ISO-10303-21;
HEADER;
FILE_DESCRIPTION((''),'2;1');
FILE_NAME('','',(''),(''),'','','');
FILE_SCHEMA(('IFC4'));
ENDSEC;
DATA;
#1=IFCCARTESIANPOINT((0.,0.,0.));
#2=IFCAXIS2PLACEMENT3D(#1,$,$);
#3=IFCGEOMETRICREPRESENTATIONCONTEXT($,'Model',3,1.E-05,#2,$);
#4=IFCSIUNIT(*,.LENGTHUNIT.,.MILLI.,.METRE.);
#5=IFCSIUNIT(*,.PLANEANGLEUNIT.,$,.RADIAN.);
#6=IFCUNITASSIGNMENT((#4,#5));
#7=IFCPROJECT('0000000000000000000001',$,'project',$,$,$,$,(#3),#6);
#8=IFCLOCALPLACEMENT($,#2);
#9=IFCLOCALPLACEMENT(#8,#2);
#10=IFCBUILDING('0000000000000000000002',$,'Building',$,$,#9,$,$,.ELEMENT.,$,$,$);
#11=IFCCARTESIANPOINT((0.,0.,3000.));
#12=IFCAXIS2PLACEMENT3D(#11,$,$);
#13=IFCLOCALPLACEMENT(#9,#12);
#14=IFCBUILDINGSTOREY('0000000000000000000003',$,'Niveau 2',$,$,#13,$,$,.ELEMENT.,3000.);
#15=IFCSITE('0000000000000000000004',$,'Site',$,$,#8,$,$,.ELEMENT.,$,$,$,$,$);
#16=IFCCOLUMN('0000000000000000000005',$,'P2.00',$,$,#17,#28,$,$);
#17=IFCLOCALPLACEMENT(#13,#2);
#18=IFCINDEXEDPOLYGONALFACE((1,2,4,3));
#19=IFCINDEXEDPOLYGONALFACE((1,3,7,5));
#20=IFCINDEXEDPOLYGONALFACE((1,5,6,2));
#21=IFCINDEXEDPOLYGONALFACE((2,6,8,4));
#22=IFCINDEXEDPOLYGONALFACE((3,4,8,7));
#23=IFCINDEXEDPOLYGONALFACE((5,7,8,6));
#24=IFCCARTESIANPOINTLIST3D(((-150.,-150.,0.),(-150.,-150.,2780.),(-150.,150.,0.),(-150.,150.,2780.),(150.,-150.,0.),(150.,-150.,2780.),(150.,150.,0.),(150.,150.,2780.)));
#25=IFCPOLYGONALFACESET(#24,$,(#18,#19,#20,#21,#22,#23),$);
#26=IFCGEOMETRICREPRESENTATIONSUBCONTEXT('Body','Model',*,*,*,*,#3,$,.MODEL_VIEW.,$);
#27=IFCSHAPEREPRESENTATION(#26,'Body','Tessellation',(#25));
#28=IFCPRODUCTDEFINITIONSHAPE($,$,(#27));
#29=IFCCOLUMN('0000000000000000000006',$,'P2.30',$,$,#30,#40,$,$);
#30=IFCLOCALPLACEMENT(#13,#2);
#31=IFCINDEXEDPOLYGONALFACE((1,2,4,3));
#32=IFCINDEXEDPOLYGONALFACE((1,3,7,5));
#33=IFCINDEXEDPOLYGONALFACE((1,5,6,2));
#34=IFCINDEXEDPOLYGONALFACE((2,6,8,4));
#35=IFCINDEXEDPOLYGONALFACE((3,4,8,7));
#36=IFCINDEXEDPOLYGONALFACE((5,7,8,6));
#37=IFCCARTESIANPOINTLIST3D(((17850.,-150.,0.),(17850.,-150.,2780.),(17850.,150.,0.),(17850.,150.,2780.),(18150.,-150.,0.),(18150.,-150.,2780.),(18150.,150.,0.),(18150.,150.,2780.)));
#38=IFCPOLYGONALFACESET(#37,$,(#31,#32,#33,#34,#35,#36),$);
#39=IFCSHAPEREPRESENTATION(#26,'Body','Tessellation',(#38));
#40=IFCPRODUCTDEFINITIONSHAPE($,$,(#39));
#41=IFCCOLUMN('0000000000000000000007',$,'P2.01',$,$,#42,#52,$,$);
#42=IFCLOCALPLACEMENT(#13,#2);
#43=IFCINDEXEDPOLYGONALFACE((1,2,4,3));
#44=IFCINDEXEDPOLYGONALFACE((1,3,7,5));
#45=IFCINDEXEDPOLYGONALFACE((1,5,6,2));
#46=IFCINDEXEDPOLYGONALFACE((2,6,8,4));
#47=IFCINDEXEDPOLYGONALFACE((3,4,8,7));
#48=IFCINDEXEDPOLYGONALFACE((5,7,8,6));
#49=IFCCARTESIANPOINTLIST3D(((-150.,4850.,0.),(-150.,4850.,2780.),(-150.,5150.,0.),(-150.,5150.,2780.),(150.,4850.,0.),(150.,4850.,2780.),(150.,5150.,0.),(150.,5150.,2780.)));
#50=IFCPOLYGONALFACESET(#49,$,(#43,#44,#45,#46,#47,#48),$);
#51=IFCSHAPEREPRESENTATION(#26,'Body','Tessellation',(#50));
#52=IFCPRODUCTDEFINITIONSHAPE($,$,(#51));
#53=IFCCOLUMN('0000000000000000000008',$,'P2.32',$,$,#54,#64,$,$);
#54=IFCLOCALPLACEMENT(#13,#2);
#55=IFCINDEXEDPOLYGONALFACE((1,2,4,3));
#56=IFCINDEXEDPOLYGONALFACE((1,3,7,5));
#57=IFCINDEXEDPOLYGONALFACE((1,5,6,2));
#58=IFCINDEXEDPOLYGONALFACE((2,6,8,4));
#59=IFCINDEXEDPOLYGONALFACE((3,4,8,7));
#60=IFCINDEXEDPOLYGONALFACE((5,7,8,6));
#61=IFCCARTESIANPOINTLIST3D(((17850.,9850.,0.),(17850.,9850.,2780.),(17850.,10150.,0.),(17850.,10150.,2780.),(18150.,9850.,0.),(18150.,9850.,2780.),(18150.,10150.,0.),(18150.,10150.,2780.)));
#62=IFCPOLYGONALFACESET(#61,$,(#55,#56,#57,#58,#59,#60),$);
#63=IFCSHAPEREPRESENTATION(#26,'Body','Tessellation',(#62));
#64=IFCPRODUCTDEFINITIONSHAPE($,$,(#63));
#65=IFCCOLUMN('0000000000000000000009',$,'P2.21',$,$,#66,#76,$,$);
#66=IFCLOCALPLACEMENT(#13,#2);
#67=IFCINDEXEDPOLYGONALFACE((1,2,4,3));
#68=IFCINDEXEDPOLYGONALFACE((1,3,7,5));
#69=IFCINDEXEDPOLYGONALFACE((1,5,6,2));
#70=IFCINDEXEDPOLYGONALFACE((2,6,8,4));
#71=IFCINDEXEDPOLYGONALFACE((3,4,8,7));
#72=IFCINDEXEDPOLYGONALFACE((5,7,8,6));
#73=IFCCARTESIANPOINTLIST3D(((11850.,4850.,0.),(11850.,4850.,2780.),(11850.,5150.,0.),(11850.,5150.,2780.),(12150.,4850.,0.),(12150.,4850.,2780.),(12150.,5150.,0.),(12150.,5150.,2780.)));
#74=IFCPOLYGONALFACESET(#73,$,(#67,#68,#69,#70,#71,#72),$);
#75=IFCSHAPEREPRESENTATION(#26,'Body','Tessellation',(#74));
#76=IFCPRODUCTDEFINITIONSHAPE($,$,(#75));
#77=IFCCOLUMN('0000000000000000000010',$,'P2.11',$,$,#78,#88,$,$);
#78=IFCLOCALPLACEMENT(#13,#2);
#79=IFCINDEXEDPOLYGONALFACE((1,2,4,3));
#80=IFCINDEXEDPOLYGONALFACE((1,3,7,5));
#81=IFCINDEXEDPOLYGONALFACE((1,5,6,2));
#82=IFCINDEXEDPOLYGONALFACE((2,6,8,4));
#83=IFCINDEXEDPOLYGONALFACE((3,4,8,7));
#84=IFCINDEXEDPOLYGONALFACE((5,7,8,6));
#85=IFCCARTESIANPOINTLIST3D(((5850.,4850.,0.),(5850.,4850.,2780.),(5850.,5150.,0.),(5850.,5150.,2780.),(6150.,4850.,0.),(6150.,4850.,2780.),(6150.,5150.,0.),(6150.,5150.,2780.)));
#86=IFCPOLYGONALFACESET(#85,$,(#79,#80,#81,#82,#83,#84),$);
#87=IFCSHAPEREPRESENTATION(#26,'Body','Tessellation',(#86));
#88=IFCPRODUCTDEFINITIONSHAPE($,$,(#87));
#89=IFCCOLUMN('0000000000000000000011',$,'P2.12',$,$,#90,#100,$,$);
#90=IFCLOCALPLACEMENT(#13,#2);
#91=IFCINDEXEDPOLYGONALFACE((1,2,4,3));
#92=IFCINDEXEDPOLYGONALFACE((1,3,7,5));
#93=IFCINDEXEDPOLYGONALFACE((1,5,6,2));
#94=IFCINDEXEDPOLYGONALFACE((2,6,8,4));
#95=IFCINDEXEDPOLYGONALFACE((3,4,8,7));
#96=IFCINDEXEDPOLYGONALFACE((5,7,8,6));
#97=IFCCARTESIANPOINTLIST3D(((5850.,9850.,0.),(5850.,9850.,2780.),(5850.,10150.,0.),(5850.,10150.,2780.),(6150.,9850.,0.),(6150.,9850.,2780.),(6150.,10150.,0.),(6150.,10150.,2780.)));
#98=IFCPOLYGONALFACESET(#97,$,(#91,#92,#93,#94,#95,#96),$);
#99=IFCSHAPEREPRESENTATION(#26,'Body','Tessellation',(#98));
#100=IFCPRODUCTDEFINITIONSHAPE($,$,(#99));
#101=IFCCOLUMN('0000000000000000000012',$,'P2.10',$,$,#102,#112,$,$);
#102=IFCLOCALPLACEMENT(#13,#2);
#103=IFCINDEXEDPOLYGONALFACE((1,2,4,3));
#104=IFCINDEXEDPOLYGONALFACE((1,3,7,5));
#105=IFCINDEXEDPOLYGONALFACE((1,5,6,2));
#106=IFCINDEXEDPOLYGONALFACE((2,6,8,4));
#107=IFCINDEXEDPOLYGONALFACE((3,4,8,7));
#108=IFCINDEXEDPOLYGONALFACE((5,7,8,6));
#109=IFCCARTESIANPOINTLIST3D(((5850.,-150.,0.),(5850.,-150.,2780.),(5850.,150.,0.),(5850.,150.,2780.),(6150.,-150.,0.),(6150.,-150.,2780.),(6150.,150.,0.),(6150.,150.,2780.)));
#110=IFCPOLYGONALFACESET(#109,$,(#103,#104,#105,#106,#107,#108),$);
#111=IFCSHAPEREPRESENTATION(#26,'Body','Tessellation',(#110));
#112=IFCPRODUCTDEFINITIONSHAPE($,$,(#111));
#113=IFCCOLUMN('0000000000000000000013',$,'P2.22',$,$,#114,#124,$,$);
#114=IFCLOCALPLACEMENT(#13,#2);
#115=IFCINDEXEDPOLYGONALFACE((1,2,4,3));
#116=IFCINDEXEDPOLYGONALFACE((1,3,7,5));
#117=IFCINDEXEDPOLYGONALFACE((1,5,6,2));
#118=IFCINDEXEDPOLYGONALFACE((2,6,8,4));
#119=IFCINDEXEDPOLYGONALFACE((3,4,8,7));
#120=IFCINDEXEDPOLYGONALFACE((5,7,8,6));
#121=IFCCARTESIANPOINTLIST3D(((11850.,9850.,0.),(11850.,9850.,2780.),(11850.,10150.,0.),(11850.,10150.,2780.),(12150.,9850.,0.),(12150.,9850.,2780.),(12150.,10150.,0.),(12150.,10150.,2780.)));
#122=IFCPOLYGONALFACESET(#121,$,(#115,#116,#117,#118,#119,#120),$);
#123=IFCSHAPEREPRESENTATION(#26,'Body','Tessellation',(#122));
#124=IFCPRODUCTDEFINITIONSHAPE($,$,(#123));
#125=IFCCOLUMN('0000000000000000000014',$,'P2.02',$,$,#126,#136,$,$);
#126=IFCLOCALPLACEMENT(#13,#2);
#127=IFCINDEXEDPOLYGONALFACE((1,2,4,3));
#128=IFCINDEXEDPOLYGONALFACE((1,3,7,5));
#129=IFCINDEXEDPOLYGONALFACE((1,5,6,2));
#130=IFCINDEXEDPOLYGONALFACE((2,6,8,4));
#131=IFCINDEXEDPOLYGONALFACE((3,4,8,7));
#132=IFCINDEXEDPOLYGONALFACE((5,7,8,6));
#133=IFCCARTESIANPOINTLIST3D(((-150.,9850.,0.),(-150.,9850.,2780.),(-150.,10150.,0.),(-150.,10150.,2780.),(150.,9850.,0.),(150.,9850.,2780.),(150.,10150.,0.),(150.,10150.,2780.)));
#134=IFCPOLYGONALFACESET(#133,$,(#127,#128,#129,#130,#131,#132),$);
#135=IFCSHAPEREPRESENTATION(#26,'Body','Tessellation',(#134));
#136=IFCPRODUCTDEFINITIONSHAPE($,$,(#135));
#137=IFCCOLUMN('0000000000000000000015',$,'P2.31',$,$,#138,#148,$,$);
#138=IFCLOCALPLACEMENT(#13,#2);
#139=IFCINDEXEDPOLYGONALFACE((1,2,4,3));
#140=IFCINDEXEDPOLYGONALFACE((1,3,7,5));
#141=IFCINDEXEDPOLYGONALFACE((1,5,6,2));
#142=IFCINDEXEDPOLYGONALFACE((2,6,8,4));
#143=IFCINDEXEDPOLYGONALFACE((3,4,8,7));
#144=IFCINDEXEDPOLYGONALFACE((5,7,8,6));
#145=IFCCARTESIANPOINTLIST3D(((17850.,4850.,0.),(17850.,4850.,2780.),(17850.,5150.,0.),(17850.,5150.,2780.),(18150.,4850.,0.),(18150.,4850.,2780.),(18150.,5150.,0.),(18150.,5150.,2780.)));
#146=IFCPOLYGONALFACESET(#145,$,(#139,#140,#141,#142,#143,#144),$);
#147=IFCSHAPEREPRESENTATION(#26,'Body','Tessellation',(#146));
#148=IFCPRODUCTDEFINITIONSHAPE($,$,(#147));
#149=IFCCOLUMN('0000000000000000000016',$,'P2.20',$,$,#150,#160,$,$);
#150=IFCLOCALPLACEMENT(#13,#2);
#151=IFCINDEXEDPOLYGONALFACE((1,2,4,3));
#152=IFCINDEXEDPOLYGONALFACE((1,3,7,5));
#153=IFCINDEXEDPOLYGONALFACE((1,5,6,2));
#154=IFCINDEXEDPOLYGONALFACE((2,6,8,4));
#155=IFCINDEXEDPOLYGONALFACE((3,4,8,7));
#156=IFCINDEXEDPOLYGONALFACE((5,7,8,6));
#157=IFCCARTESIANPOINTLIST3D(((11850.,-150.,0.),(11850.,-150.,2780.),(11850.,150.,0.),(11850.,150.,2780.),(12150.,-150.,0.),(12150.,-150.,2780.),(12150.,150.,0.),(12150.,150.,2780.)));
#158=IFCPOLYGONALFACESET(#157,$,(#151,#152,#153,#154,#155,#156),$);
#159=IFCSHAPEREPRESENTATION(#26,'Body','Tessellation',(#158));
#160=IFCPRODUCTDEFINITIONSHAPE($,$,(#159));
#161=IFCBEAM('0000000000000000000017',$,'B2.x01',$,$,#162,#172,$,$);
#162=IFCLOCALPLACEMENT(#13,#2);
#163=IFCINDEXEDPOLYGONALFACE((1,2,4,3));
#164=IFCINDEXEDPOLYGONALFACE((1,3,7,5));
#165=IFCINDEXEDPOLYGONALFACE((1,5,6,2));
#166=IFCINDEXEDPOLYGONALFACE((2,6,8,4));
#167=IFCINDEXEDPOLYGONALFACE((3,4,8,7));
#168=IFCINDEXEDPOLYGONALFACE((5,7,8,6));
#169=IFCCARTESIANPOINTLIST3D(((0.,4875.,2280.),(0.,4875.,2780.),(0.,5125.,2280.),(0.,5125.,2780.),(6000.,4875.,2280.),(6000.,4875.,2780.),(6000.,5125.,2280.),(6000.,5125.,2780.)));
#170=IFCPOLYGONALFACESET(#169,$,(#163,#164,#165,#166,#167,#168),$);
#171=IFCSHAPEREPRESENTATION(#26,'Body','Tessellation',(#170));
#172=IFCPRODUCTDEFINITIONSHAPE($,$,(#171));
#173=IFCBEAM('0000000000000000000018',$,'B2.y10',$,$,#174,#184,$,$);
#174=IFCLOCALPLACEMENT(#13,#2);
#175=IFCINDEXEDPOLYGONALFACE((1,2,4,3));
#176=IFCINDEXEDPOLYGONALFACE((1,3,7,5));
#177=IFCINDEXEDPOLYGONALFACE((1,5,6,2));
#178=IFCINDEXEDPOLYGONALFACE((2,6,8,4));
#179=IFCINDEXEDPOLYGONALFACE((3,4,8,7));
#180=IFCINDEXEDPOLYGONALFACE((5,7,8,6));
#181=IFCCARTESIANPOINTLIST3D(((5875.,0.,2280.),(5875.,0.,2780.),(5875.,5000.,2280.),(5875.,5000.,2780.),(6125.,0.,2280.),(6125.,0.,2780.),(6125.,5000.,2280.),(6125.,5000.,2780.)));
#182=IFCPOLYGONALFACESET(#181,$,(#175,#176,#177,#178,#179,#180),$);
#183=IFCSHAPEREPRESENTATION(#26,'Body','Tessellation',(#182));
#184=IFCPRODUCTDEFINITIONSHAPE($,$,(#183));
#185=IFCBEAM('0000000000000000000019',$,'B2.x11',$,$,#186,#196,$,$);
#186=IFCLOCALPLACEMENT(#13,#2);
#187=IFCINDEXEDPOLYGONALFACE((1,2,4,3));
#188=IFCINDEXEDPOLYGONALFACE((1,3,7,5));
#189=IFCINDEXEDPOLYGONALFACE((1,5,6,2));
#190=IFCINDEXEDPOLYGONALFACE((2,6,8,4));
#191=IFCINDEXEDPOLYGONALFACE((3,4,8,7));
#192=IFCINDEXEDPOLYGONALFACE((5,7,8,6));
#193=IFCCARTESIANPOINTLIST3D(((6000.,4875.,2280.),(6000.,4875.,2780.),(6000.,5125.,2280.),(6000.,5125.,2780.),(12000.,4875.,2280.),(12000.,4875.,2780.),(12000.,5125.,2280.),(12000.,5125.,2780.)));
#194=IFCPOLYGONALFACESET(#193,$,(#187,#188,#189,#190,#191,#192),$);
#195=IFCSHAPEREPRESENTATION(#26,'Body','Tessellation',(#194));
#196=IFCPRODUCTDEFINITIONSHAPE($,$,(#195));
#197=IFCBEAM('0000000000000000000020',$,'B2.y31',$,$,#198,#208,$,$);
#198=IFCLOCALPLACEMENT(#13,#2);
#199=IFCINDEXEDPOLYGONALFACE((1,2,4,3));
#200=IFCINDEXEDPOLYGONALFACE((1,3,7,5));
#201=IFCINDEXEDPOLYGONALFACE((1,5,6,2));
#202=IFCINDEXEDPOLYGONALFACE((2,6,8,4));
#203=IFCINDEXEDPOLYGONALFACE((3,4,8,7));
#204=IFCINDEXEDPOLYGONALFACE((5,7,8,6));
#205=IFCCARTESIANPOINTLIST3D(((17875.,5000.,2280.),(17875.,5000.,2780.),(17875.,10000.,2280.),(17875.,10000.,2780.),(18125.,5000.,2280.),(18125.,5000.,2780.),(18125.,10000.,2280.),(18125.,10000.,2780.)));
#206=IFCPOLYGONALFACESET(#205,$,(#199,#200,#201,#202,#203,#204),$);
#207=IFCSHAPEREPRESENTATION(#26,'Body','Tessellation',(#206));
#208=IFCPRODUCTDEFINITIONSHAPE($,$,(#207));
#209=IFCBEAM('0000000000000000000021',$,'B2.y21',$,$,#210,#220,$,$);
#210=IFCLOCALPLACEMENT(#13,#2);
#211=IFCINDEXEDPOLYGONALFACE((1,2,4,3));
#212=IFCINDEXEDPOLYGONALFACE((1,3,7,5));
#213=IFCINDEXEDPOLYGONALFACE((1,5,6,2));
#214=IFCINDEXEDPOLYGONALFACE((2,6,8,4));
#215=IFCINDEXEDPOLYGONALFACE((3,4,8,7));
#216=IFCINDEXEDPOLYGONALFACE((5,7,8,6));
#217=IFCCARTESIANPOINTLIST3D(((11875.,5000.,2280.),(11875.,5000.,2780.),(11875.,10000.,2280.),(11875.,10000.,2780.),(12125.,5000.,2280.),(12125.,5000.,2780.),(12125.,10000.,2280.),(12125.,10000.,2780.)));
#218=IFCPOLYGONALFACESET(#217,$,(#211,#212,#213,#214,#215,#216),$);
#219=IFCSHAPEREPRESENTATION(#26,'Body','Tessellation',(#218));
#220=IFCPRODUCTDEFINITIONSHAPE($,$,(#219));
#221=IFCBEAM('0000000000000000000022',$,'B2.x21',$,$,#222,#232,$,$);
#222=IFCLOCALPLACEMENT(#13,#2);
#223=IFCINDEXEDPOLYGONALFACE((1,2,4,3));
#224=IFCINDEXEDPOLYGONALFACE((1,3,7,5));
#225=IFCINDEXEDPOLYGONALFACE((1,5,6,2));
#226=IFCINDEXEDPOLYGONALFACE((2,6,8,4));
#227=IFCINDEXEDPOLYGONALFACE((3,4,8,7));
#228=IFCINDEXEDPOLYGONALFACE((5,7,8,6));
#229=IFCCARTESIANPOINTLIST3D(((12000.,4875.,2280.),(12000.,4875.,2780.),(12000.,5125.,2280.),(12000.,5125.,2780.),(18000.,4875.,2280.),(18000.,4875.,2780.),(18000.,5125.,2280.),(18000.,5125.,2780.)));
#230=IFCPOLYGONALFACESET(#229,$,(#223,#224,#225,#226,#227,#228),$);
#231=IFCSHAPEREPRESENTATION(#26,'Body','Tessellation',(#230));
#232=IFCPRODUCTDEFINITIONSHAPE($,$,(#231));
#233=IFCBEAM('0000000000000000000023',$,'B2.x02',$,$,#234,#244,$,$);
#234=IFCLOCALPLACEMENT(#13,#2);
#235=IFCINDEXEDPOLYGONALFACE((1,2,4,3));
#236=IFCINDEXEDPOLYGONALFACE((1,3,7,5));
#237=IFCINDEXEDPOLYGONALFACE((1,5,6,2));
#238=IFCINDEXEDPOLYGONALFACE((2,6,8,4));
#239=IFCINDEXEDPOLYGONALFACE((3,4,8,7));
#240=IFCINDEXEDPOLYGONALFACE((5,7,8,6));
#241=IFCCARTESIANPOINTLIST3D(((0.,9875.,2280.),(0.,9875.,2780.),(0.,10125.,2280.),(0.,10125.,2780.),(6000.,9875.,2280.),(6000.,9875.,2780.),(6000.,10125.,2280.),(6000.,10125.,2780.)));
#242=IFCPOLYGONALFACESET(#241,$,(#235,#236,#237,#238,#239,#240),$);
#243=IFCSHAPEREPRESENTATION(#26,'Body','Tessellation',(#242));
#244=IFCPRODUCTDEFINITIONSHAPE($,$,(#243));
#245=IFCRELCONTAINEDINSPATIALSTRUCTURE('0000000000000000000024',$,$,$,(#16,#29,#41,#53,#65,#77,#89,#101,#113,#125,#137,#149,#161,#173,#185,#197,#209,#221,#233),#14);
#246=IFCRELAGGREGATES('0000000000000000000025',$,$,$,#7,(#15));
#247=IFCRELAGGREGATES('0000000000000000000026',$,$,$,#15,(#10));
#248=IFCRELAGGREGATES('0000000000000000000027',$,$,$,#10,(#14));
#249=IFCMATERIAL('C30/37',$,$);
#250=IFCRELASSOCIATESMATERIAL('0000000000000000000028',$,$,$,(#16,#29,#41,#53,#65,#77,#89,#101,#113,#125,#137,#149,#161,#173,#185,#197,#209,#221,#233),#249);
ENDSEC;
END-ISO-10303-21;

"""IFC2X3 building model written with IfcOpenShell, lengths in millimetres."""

from ifc_helpers import new_model, si_unit, frame, origin, origin_2d, place, context, subcontext, project, spatial, rectangle, extrude, material, element, save


model = new_model("IFC2X3")

# Units and contexts
model_context = context("Model", 3, precision=1e-05, world=origin())
body_context = subcontext(model_context, "Body", "Model", "MODEL_VIEW")
ifc_project = project(units=[si_unit("LENGTHUNIT", "METRE", prefix="MILLI"), si_unit("PLANEANGLEUNIT", "RADIAN")], contexts=[model_context])

# Site, building, storey
site_placement = place(None, origin())
site = spatial("IfcSite", under=ifc_project, at=site_placement, Name="Site", CompositionType="ELEMENT")
building_placement = place(site_placement, origin())
building = spatial("IfcBuilding", under=site, at=building_placement, Name="Building", CompositionType="ELEMENT")
storey_placement = place(building_placement, frame((0.0, 0.0, 3000.0)))
storey = spatial("IfcBuildingStorey", under=building, at=storey_placement, Name="Niveau 2", CompositionType="ELEMENT", Elevation=3000.0)

# Columns
ifc_material = material(Name="C30/37")
for number, where, z_axis, x_axis, name in (
    (1, (0.0, 0.0, 0.0), (0.0, 0.0, 1.0), (1.0, 0.0, 0.0), "P2.00"),
    (2, (18000.0, 0.0, 0.0), (0.0, 0.0, 1.0), (1.0, 0.0, 0.0), "P2.30"),
    (3, (0.0, 5000.0, 0.0), (0.0, 0.0, 1.0), (1.0, 0.0, 0.0), "P2.01"),
    (4, (18000.0, 10000.0, 0.0), (0.0, 0.0, 1.0), (1.0, 0.0, 0.0), "P2.32"),
    (5, (12000.0, 5000.0, 0.0), (0.0, 0.0, 1.0), (1.0, 0.0, 0.0), "P2.21"),
    (6, (6000.0, 5000.0, 0.0), (0.0, 0.0, 1.0), (1.0, 0.0, 0.0), "P2.11"),
    (7, (6000.0, 10000.0, 0.0), (0.0, 0.0, 1.0), (1.0, 0.0, 0.0), "P2.12"),
    (8, (6000.0, 0.0, 0.0), (0.0, 0.0, 1.0), (1.0, 0.0, 0.0), "P2.10"),
    (9, (12000.0, 10000.0, 0.0), (0.0, 0.0, 1.0), (1.0, 0.0, 0.0), "P2.22"),
    (10, (0.0, 10000.0, 0.0), (0.0, 0.0, 1.0), (1.0, 0.0, 0.0), "P2.02"),
    (11, (18000.0, 5000.0, 0.0), (0.0, 0.0, 1.0), (1.0, 0.0, 0.0), "P2.31"),
    (12, (12000.0, 0.0, 0.0), (0.0, 0.0, 1.0), (1.0, 0.0, 0.0), "P2.20"),
):
    element("IfcColumn", number, at=place(storey_placement, frame(where, z_axis=z_axis, x_axis=x_axis)), inside=storey, material=ifc_material, Name=name, context=body_context, shape_type="SweptSolid", body=[
        extrude(rectangle(XDim=300.0, YDim=300.0, at=origin_2d()), origin(), (0.0, 0.0, 1.0), 2780.0),
    ])

# Beams
beam_1_placement = place(storey_placement, frame((0.0, 5000.0, 2530.0), z_axis=(1.0, 0.0, 0.0), x_axis=(0.0, 1.0, 0.0)))
element("IfcBeam", 13, at=beam_1_placement, inside=storey, material=ifc_material, Name="B2.x01", context=body_context, shape_type="SweptSolid", body=[
    extrude(rectangle(XDim=250.0, YDim=500.0, at=origin_2d()), origin(), (0.0, 0.0, 1.0), 6000.0),
])
beam_2_placement = place(storey_placement, frame((6000.0, 0.0, 2530.0), z_axis=(0.0, 1.0, 0.0), x_axis=(-1.0, 0.0, 0.0)))
element("IfcBeam", 14, at=beam_2_placement, inside=storey, material=ifc_material, Name="B2.y10", context=body_context, shape_type="SweptSolid", body=[
    extrude(rectangle(XDim=250.0, YDim=500.0, at=origin_2d()), origin(), (0.0, 0.0, 1.0), 5000.0),
])
beam_3_placement = place(storey_placement, frame((6000.0, 5000.0, 2530.0), z_axis=(1.0, 0.0, 0.0), x_axis=(0.0, 1.0, 0.0)))
element("IfcBeam", 15, at=beam_3_placement, inside=storey, material=ifc_material, Name="B2.x11", context=body_context, shape_type="SweptSolid", body=[
    extrude(rectangle(XDim=250.0, YDim=500.0, at=origin_2d()), origin(), (0.0, 0.0, 1.0), 6000.0),
])
for number, where, z_axis, x_axis, name in (
    (16, (18000.0, 5000.0, 2530.0), (0.0, 1.0, 0.0), (-1.0, 0.0, 0.0), "B2.y31"),
    (17, (12000.0, 5000.0, 2530.0), (0.0, 1.0, 0.0), (-1.0, 0.0, 0.0), "B2.y21"),
):
    element("IfcBeam", number, at=place(storey_placement, frame(where, z_axis=z_axis, x_axis=x_axis)), inside=storey, material=ifc_material, Name=name, context=body_context, shape_type="SweptSolid", body=[
        extrude(rectangle(XDim=250.0, YDim=500.0, at=origin_2d()), origin(), (0.0, 0.0, 1.0), 5000.0),
    ])
for number, where, z_axis, x_axis, name in (
    (18, (12000.0, 5000.0, 2530.0), (1.0, 0.0, 0.0), (0.0, 1.0, 0.0), "B2.x21"),
    (19, (0.0, 10000.0, 2530.0), (1.0, 0.0, 0.0), (0.0, 1.0, 0.0), "B2.x02"),
):
    element("IfcBeam", number, at=place(storey_placement, frame(where, z_axis=z_axis, x_axis=x_axis)), inside=storey, material=ifc_material, Name=name, context=body_context, shape_type="SweptSolid", body=[
        extrude(rectangle(XDim=250.0, YDim=500.0, at=origin_2d()), origin(), (0.0, 0.0, 1.0), 6000.0),
    ])

save(model, "model.ifc")
